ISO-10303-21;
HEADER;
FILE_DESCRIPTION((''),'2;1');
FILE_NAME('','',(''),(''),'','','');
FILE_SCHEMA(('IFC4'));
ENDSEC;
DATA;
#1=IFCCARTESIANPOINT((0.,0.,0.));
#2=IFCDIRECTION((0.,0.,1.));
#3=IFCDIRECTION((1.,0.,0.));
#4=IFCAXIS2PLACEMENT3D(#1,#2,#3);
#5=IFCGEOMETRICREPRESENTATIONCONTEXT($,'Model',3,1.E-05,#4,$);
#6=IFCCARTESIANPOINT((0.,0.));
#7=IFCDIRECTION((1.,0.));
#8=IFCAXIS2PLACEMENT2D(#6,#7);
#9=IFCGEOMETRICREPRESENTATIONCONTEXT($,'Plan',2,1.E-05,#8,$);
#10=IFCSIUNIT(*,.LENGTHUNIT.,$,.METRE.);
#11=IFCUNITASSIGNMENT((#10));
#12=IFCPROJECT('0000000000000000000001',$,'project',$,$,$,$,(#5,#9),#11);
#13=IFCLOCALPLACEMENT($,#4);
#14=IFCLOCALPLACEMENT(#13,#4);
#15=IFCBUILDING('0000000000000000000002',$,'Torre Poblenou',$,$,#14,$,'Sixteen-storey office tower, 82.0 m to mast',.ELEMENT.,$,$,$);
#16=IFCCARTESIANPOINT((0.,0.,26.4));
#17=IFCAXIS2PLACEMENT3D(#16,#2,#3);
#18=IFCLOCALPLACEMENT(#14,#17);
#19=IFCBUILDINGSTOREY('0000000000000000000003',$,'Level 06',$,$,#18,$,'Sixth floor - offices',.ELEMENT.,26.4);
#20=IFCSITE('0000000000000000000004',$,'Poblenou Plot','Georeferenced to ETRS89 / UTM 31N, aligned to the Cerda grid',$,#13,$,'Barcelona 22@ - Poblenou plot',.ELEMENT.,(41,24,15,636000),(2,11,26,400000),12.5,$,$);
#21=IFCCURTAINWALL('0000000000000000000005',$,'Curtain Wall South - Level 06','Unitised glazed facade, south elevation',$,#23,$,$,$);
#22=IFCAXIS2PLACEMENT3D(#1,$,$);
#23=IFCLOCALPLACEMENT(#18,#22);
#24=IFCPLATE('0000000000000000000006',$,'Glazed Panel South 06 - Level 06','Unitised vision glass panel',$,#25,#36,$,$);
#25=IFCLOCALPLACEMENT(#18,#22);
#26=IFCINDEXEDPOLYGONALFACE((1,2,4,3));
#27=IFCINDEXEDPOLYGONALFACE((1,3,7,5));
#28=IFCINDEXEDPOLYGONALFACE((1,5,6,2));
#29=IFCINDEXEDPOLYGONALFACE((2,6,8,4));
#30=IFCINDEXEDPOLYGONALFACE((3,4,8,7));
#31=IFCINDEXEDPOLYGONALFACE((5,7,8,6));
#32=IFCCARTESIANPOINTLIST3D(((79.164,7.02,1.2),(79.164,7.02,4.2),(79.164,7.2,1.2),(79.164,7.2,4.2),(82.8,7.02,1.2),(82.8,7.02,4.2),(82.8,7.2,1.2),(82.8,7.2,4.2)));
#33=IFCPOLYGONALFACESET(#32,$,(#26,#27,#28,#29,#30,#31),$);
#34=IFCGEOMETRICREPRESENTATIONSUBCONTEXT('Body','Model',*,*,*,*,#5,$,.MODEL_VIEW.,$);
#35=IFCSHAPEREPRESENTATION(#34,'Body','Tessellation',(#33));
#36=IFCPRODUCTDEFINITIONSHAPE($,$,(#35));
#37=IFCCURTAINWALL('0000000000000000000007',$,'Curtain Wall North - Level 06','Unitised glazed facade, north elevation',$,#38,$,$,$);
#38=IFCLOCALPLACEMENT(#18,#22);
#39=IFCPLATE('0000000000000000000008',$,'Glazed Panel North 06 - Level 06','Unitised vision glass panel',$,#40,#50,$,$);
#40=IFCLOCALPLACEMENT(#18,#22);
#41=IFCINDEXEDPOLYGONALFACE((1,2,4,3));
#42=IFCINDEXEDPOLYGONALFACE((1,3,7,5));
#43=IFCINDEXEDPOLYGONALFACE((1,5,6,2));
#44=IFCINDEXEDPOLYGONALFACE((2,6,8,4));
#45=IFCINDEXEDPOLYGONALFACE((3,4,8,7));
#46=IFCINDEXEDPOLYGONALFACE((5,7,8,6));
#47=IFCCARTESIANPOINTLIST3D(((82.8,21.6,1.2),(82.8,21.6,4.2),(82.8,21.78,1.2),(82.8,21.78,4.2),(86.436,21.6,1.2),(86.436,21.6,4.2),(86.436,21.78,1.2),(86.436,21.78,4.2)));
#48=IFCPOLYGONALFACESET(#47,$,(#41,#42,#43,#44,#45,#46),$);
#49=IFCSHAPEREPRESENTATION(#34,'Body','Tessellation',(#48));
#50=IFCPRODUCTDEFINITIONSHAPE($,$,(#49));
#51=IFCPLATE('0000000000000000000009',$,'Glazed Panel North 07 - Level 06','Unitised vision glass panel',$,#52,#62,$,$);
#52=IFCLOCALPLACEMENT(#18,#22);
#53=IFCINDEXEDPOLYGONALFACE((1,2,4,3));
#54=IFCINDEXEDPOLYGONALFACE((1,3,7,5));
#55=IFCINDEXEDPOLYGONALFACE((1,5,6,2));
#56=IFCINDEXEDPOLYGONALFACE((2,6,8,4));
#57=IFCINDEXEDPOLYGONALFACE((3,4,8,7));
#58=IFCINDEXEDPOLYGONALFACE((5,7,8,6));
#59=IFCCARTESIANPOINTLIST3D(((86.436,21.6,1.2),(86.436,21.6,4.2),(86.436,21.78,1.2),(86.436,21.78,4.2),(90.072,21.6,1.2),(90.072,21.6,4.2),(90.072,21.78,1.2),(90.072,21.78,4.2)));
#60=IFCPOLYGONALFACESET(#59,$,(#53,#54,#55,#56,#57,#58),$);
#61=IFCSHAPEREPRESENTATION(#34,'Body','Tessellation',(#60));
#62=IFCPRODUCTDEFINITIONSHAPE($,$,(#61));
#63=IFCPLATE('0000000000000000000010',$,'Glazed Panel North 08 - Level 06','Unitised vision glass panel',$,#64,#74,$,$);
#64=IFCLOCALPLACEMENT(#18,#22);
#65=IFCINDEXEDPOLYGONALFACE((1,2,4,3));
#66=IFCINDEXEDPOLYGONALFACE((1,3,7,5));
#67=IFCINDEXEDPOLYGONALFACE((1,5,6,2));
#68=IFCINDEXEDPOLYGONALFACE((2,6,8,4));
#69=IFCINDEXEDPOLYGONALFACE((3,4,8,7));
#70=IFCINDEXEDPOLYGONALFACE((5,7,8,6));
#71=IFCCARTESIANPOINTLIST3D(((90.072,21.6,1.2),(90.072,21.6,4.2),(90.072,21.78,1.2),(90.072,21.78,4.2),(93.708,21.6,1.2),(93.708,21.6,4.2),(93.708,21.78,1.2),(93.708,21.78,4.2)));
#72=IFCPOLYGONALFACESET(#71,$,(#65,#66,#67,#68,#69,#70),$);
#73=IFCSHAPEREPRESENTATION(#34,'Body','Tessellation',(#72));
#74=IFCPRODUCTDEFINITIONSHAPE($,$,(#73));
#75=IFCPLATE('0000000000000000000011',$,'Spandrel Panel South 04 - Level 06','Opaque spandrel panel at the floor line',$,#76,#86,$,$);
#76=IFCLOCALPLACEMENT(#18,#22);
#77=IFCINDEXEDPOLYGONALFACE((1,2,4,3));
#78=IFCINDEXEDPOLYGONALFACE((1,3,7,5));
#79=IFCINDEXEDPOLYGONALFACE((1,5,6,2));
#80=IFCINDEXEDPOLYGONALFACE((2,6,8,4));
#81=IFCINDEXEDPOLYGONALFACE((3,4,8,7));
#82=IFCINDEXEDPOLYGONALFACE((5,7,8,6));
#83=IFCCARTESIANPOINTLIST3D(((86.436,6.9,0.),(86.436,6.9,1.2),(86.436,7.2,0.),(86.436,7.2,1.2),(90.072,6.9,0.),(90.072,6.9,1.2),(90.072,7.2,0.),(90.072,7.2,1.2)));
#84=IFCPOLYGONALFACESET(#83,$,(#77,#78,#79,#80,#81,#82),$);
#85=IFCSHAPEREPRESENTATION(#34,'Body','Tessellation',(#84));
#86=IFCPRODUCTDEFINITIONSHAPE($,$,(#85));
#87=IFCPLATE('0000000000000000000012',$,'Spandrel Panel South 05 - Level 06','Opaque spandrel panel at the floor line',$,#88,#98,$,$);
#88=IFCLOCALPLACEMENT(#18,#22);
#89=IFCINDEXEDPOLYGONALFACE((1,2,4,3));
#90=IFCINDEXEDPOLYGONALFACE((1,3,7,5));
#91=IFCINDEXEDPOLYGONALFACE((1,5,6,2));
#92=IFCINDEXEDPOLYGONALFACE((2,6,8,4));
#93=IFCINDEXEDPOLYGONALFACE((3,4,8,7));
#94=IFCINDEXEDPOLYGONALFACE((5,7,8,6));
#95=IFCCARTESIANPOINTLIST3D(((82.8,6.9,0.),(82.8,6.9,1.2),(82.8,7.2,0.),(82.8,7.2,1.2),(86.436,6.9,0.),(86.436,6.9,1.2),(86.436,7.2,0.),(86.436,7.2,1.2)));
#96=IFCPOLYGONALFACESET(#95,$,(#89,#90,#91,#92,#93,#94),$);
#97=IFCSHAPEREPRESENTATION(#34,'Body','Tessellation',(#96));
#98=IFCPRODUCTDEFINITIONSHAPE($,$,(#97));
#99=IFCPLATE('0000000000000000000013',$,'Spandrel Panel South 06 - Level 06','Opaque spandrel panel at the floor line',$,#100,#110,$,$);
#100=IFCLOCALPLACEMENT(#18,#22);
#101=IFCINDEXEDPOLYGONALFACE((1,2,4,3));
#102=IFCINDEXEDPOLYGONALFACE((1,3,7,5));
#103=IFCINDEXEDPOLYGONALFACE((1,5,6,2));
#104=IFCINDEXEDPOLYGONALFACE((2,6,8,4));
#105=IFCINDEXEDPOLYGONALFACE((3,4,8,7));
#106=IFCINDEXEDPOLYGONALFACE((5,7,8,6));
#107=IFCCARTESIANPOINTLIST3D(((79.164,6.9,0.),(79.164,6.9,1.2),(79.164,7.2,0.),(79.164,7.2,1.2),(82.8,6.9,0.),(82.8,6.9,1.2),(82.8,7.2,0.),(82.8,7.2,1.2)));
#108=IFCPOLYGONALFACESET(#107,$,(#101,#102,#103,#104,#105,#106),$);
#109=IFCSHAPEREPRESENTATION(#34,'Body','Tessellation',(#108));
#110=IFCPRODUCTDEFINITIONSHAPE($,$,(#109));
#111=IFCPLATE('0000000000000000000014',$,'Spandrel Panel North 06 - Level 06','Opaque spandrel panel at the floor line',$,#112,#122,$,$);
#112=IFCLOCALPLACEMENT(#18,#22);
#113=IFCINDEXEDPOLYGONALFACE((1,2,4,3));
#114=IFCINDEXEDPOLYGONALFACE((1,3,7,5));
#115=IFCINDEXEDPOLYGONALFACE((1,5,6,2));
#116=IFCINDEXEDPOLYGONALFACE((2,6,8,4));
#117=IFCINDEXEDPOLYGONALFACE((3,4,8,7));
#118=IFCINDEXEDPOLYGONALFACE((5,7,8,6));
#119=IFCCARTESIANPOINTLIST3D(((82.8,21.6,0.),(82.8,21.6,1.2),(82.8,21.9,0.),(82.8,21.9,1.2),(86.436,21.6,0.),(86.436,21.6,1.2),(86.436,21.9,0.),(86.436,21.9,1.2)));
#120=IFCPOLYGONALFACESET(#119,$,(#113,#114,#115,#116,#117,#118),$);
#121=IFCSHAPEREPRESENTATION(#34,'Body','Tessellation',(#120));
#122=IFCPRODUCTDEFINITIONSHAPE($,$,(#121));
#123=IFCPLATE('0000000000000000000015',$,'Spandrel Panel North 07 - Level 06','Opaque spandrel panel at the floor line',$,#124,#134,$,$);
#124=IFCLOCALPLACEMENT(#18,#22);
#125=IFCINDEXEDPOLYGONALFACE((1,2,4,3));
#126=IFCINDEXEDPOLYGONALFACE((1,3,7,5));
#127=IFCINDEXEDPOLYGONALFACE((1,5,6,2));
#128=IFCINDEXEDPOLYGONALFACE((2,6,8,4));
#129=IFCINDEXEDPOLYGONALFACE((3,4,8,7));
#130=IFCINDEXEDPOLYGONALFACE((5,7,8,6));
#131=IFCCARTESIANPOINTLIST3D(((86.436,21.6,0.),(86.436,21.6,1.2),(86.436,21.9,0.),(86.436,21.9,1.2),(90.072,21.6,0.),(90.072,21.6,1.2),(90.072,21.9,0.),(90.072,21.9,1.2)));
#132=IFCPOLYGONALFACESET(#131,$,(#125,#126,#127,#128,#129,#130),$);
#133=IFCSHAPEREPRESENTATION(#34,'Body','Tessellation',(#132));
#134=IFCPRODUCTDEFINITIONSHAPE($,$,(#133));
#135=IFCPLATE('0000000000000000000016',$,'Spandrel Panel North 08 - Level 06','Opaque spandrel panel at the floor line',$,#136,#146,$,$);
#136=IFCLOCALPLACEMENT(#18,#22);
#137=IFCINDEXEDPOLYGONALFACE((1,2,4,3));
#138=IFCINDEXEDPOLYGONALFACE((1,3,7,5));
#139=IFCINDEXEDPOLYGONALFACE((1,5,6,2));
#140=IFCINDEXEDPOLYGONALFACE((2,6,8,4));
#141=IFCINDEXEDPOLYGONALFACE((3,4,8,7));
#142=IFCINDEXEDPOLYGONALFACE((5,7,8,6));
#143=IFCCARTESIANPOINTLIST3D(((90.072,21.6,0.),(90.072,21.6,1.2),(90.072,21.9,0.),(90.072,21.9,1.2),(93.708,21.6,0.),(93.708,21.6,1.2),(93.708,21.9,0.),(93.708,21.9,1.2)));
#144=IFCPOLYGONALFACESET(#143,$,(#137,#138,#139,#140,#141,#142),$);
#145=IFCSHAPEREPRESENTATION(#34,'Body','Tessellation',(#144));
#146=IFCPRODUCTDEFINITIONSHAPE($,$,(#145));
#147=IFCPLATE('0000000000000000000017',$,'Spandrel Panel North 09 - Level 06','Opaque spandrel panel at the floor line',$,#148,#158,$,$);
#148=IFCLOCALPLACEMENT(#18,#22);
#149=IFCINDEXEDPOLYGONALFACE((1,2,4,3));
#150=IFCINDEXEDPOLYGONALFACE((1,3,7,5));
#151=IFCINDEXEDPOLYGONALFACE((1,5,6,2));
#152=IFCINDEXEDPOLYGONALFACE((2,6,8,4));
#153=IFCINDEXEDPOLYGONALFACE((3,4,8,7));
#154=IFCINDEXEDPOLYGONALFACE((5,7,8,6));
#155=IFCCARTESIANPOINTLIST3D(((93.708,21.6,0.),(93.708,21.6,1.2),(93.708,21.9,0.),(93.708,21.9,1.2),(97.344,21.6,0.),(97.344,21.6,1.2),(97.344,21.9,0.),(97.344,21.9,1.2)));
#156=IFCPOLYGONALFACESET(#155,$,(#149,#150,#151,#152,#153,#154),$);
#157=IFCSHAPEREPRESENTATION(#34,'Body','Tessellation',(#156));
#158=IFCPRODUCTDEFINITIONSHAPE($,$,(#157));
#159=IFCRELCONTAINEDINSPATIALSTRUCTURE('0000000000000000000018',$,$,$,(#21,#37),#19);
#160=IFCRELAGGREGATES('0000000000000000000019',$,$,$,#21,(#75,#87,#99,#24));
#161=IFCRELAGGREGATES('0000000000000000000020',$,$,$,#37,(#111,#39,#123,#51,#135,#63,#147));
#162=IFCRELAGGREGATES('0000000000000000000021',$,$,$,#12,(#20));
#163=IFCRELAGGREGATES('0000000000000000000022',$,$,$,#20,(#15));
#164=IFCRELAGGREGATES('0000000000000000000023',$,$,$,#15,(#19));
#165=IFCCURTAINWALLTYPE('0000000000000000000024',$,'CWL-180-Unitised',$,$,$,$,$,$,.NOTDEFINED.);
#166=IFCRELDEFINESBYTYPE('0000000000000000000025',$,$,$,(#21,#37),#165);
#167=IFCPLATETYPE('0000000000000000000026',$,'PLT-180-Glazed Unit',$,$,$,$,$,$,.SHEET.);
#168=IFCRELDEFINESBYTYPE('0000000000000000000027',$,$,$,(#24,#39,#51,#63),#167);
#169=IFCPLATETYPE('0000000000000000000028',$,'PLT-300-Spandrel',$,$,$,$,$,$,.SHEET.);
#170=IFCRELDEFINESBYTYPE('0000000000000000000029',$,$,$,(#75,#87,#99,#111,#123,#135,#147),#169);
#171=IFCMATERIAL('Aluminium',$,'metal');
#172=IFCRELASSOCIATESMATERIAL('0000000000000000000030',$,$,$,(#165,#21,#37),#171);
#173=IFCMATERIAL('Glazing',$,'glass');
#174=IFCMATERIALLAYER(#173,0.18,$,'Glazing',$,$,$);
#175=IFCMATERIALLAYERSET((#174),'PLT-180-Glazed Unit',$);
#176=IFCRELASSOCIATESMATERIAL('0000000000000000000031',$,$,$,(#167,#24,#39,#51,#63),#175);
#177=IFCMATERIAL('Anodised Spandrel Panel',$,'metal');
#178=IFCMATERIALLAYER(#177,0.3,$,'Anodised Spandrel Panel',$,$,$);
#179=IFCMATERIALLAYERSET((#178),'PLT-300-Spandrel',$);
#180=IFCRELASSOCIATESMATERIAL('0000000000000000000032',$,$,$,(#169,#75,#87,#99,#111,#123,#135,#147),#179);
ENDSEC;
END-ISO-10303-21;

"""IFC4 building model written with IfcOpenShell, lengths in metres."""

from ifc_helpers import new_model, si_unit, frame, origin_with_axes, origin_2d_with_axis, place, context, subcontext, project, spatial, line, indexed_curve, outline, extrude, material, layer, layer_set, layer_usage, type_object, element, aggregate, save


model = new_model("IFC4")

# Units and contexts
model_context = context("Model", 3, precision=1e-05, world=origin_with_axes())
plan_context = context("Plan", 2, precision=1e-05, world=origin_2d_with_axis())
body_context = subcontext(model_context, "Body", "Model", "MODEL_VIEW")
ifc_project = project(units=[si_unit("LENGTHUNIT", "METRE")], contexts=[model_context, plan_context])

# Site, building, storey
site_placement = place(None, origin_with_axes())
site = spatial("IfcSite", under=ifc_project, at=site_placement, Name="Poblenou Plot", Description="Georeferenced to ETRS89 / UTM 31N, aligned to the Cerda grid", LongName="Barcelona 22@ - Poblenou plot", CompositionType="ELEMENT", RefLatitude=(41, 24, 15, 636000), RefLongitude=(2, 11, 26, 400000), RefElevation=12.5)
building_placement = place(site_placement, origin_with_axes())
building = spatial("IfcBuilding", under=site, at=building_placement, Name="Torre Poblenou", LongName="Sixteen-storey office tower, 82.0 m to mast", CompositionType="ELEMENT")
storey_placement = place(building_placement, frame((0.0, 0.0, 26.4), z_axis=(0.0, 0.0, 1.0), x_axis=(1.0, 0.0, 0.0)))
storey = spatial("IfcBuildingStorey", under=building, at=storey_placement, Name="Level 06", LongName="Sixth floor - offices", CompositionType="ELEMENT", Elevation=26.4)

# Curtain walls, plates
ifc_material_1 = material(Name="Aluminium", Category="metal")
curtain_wall_type = type_object("IfcCurtainWallType", Name="CWL-180-Unitised", PredefinedType="NOTDEFINED", material=ifc_material_1)
curtain_wall_1_placement = place(storey_placement, frame((100.98, 7.2, 0.0), z_axis=(0.0, 0.0, 1.0), x_axis=(-1.0, 0.0, 0.0)))
curtain_wall_1 = element("IfcCurtainWall", 1, at=curtain_wall_1_placement, inside=storey, type_object=curtain_wall_type, material=ifc_material_1, Name="Curtain Wall South - Level 06", Description="Unitised glazed facade, south elevation")
ifc_material_2 = material(Name="Glazing", Category="glass")
ifc_layer_1 = layer(ifc_material_2, 0.18, Name="Glazing")
ifc_layer_set_1 = layer_set([ifc_layer_1], Name="PLT-180-Glazed Unit")
plate_type_1 = type_object("IfcPlateType", Name="PLT-180-Glazed Unit", PredefinedType="SHEET", material=ifc_layer_set_1)
ifc_layer_usage_1 = layer_usage(ifc_layer_set_1, "AXIS2", "POSITIVE", 0.0)
plate_1_placement = place(curtain_wall_1_placement, frame((18.18, 0.0, 1.2), z_axis=(0.0, 0.0, 1.0), x_axis=(1.0, 0.0, 0.0)))
plate_1 = element("IfcPlate", 2, at=plate_1_placement, type_object=plate_type_1, material=ifc_layer_usage_1, Name="Glazed Panel South 06 - Level 06", Description="Unitised vision glass panel", context=body_context, shape_type="SweptSolid", body=[
    extrude(outline(indexed_curve([(0.0, 0.0), (3.636, 0.0), (3.636, 0.18), (0.0, 0.18)], segments=[line(1, 2, 3, 4, 1)])), origin_with_axes(), (0.0, 0.0, 1.0), 3.0),
])
curtain_wall_2_placement = place(storey_placement, frame((64.62, 21.6, 0.0), z_axis=(0.0, 0.0, 1.0), x_axis=(1.0, 0.0, 0.0)))
curtain_wall_2 = element("IfcCurtainWall", 3, at=curtain_wall_2_placement, inside=storey, type_object=curtain_wall_type, material=ifc_material_1, Name="Curtain Wall North - Level 06", Description="Unitised glazed facade, north elevation")
ifc_layer_usage_2 = layer_usage(ifc_layer_set_1, "AXIS2", "POSITIVE", 0.0)
plate_2_placement = place(curtain_wall_2_placement, frame((18.18, 0.0, 1.2), z_axis=(0.0, 0.0, 1.0), x_axis=(1.0, 0.0, 0.0)))
plate_2 = element("IfcPlate", 4, at=plate_2_placement, type_object=plate_type_1, material=ifc_layer_usage_2, Name="Glazed Panel North 06 - Level 06", Description="Unitised vision glass panel", context=body_context, shape_type="SweptSolid", body=[
    extrude(outline(indexed_curve([(0.0, 0.0), (3.636, 0.0), (3.636, 0.18), (0.0, 0.18)], segments=[line(1, 2, 3, 4, 1)])), origin_with_axes(), (0.0, 0.0, 1.0), 3.0),
])
ifc_layer_usage_3 = layer_usage(ifc_layer_set_1, "AXIS2", "POSITIVE", 0.0)
plate_3_placement = place(curtain_wall_2_placement, frame((21.816, 0.0, 1.2), z_axis=(0.0, 0.0, 1.0), x_axis=(1.0, 0.0, 0.0)))
plate_3 = element("IfcPlate", 5, at=plate_3_placement, type_object=plate_type_1, material=ifc_layer_usage_3, Name="Glazed Panel North 07 - Level 06", Description="Unitised vision glass panel", context=body_context, shape_type="SweptSolid", body=[
    extrude(outline(indexed_curve([(0.0, 0.0), (3.636, 0.0), (3.636, 0.18), (0.0, 0.18)], segments=[line(1, 2, 3, 4, 1)])), origin_with_axes(), (0.0, 0.0, 1.0), 3.0),
])
ifc_layer_usage_4 = layer_usage(ifc_layer_set_1, "AXIS2", "POSITIVE", 0.0)
plate_4_placement = place(curtain_wall_2_placement, frame((25.452, 0.0, 1.2), z_axis=(0.0, 0.0, 1.0), x_axis=(1.0, 0.0, 0.0)))
plate_4 = element("IfcPlate", 6, at=plate_4_placement, type_object=plate_type_1, material=ifc_layer_usage_4, Name="Glazed Panel North 08 - Level 06", Description="Unitised vision glass panel", context=body_context, shape_type="SweptSolid", body=[
    extrude(outline(indexed_curve([(0.0, 0.0), (3.636, 0.0), (3.636, 0.18), (0.0, 0.18)], segments=[line(1, 2, 3, 4, 1)])), origin_with_axes(), (0.0, 0.0, 1.0), 3.0),
])

# Plates
ifc_material_3 = material(Name="Anodised Spandrel Panel", Category="metal")
ifc_layer_2 = layer(ifc_material_3, 0.3, Name="Anodised Spandrel Panel")
ifc_layer_set_2 = layer_set([ifc_layer_2], Name="PLT-300-Spandrel")
ifc_layer_usage_5 = layer_usage(ifc_layer_set_2, "AXIS2", "POSITIVE", 0.0)
plate_type_2 = type_object("IfcPlateType", Name="PLT-300-Spandrel", PredefinedType="SHEET", material=ifc_layer_set_2)
plate_5_placement = place(curtain_wall_1_placement, frame((10.908, 0.0, 0.0), z_axis=(0.0, 0.0, 1.0), x_axis=(1.0, 0.0, 0.0)))
plate_5 = element("IfcPlate", 7, at=plate_5_placement, type_object=plate_type_2, material=ifc_layer_usage_5, Name="Spandrel Panel South 04 - Level 06", Description="Opaque spandrel panel at the floor line", context=body_context, shape_type="SweptSolid", body=[
    extrude(outline(indexed_curve([(0.0, 0.0), (3.636, 0.0), (3.636, 0.3), (0.0, 0.3)], segments=[line(1, 2, 3, 4, 1)])), origin_with_axes(), (0.0, 0.0, 1.0), 1.2),
])
ifc_layer_usage_6 = layer_usage(ifc_layer_set_2, "AXIS2", "POSITIVE", 0.0)
plate_6_placement = place(curtain_wall_1_placement, frame((14.544, 0.0, 0.0), z_axis=(0.0, 0.0, 1.0), x_axis=(1.0, 0.0, 0.0)))
plate_6 = element("IfcPlate", 8, at=plate_6_placement, type_object=plate_type_2, material=ifc_layer_usage_6, Name="Spandrel Panel South 05 - Level 06", Description="Opaque spandrel panel at the floor line", context=body_context, shape_type="SweptSolid", body=[
    extrude(outline(indexed_curve([(0.0, 0.0), (3.636, 0.0), (3.636, 0.3), (0.0, 0.3)], segments=[line(1, 2, 3, 4, 1)])), origin_with_axes(), (0.0, 0.0, 1.0), 1.2),
])
ifc_layer_usage_7 = layer_usage(ifc_layer_set_2, "AXIS2", "POSITIVE", 0.0)
plate_7_placement = place(curtain_wall_1_placement, frame((18.18, 0.0, 0.0), z_axis=(0.0, 0.0, 1.0), x_axis=(1.0, 0.0, 0.0)))
plate_7 = element("IfcPlate", 9, at=plate_7_placement, type_object=plate_type_2, material=ifc_layer_usage_7, Name="Spandrel Panel South 06 - Level 06", Description="Opaque spandrel panel at the floor line", context=body_context, shape_type="SweptSolid", body=[
    extrude(outline(indexed_curve([(0.0, 0.0), (3.636, 0.0), (3.636, 0.3), (0.0, 0.3)], segments=[line(1, 2, 3, 4, 1)])), origin_with_axes(), (0.0, 0.0, 1.0), 1.2),
])
aggregate(curtain_wall_1, [plate_5, plate_6, plate_7, plate_1])
ifc_layer_usage_8 = layer_usage(ifc_layer_set_2, "AXIS2", "POSITIVE", 0.0)
plate_8_placement = place(curtain_wall_2_placement, frame((18.18, 0.0, 0.0), z_axis=(0.0, 0.0, 1.0), x_axis=(1.0, 0.0, 0.0)))
plate_8 = element("IfcPlate", 10, at=plate_8_placement, type_object=plate_type_2, material=ifc_layer_usage_8, Name="Spandrel Panel North 06 - Level 06", Description="Opaque spandrel panel at the floor line", context=body_context, shape_type="SweptSolid", body=[
    extrude(outline(indexed_curve([(0.0, 0.0), (3.636, 0.0), (3.636, 0.3), (0.0, 0.3)], segments=[line(1, 2, 3, 4, 1)])), origin_with_axes(), (0.0, 0.0, 1.0), 1.2),
])
ifc_layer_usage_9 = layer_usage(ifc_layer_set_2, "AXIS2", "POSITIVE", 0.0)
plate_9_placement = place(curtain_wall_2_placement, frame((21.816, 0.0, 0.0), z_axis=(0.0, 0.0, 1.0), x_axis=(1.0, 0.0, 0.0)))
plate_9 = element("IfcPlate", 11, at=plate_9_placement, type_object=plate_type_2, material=ifc_layer_usage_9, Name="Spandrel Panel North 07 - Level 06", Description="Opaque spandrel panel at the floor line", context=body_context, shape_type="SweptSolid", body=[
    extrude(outline(indexed_curve([(0.0, 0.0), (3.636, 0.0), (3.636, 0.3), (0.0, 0.3)], segments=[line(1, 2, 3, 4, 1)])), origin_with_axes(), (0.0, 0.0, 1.0), 1.2),
])
ifc_layer_usage_10 = layer_usage(ifc_layer_set_2, "AXIS2", "POSITIVE", 0.0)
plate_10_placement = place(curtain_wall_2_placement, frame((25.452, 0.0, 0.0), z_axis=(0.0, 0.0, 1.0), x_axis=(1.0, 0.0, 0.0)))
plate_10 = element("IfcPlate", 12, at=plate_10_placement, type_object=plate_type_2, material=ifc_layer_usage_10, Name="Spandrel Panel North 08 - Level 06", Description="Opaque spandrel panel at the floor line", context=body_context, shape_type="SweptSolid", body=[
    extrude(outline(indexed_curve([(0.0, 0.0), (3.636, 0.0), (3.636, 0.3), (0.0, 0.3)], segments=[line(1, 2, 3, 4, 1)])), origin_with_axes(), (0.0, 0.0, 1.0), 1.2),
])
ifc_layer_usage_11 = layer_usage(ifc_layer_set_2, "AXIS2", "POSITIVE", 0.0)
plate_11_placement = place(curtain_wall_2_placement, frame((29.088, 0.0, 0.0), z_axis=(0.0, 0.0, 1.0), x_axis=(1.0, 0.0, 0.0)))
plate_11 = element("IfcPlate", 13, at=plate_11_placement, type_object=plate_type_2, material=ifc_layer_usage_11, Name="Spandrel Panel North 09 - Level 06", Description="Opaque spandrel panel at the floor line", context=body_context, shape_type="SweptSolid", body=[
    extrude(outline(indexed_curve([(0.0, 0.0), (3.636, 0.0), (3.636, 0.3), (0.0, 0.3)], segments=[line(1, 2, 3, 4, 1)])), origin_with_axes(), (0.0, 0.0, 1.0), 1.2),
])
aggregate(curtain_wall_2, [plate_8, plate_2, plate_9, plate_3, plate_10, plate_4, plate_11])

save(model, "model.ifc")
